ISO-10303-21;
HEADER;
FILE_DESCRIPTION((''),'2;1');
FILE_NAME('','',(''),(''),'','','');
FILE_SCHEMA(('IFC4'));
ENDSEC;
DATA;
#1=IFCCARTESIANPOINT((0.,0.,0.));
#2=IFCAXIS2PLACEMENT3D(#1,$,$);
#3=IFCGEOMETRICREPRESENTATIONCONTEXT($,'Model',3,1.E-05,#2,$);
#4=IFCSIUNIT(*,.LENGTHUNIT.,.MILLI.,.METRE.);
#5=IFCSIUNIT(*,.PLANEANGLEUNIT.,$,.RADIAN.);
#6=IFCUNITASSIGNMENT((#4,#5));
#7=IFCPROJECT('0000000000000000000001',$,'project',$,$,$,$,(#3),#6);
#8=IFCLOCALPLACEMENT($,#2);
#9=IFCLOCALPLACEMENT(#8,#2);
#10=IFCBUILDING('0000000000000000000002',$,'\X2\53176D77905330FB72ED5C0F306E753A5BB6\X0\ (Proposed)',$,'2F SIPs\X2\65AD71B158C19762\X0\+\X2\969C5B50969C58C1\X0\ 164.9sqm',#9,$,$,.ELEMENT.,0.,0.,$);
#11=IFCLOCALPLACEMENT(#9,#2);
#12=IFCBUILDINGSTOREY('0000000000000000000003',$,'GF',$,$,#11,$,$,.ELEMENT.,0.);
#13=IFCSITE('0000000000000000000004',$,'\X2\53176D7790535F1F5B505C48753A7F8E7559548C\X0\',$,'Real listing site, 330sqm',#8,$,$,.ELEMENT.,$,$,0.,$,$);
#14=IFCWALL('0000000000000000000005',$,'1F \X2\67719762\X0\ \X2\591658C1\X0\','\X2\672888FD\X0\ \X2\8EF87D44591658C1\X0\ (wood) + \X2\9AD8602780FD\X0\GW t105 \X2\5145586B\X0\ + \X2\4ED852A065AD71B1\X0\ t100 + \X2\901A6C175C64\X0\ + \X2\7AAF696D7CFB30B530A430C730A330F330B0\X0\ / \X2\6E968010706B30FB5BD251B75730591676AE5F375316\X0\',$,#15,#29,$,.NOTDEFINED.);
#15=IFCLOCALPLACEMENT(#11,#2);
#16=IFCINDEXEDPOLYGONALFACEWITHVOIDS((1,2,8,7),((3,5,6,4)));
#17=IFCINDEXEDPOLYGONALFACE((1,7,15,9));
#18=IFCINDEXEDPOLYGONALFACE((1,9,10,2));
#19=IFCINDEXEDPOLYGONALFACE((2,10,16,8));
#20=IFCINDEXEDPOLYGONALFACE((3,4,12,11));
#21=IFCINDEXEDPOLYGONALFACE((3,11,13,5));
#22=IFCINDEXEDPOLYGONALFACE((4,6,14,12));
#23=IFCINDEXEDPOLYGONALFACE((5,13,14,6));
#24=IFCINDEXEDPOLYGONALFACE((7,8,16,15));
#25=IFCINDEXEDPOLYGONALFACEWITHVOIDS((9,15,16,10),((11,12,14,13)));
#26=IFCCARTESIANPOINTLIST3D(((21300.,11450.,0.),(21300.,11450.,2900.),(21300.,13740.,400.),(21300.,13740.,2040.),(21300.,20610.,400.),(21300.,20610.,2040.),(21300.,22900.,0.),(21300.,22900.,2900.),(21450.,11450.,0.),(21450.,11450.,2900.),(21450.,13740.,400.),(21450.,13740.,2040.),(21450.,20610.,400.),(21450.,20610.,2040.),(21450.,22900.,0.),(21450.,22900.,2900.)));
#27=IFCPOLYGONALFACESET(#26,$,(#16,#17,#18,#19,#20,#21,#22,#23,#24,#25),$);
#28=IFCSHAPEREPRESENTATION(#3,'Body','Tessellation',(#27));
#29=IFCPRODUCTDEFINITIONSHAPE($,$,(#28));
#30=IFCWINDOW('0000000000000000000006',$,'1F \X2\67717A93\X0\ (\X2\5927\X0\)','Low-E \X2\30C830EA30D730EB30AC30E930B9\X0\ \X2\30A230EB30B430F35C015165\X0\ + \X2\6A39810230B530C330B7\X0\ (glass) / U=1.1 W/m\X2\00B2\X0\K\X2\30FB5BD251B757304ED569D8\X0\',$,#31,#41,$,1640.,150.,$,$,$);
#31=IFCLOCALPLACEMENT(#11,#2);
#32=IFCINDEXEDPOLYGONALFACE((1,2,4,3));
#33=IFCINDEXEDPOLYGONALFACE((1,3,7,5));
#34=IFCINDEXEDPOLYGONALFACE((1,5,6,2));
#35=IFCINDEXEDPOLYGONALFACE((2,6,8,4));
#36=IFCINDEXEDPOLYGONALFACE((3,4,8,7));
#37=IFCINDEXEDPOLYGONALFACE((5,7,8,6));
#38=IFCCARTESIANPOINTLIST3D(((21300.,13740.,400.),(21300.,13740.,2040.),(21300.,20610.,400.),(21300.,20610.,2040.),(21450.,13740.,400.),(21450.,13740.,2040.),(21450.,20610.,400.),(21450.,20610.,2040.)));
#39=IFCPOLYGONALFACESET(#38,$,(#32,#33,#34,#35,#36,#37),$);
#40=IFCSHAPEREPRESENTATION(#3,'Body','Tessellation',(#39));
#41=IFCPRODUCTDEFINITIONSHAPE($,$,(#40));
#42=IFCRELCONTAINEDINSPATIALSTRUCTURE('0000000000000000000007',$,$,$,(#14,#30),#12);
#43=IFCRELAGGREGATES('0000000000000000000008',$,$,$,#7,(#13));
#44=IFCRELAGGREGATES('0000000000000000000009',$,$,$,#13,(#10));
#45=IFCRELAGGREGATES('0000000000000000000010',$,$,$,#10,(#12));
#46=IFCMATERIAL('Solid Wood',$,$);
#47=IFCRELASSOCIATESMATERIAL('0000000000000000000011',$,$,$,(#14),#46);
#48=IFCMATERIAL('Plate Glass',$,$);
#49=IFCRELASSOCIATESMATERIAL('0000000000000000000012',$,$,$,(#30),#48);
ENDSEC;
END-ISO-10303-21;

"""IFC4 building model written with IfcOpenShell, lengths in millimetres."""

from ifc_helpers import new_model, si_unit, frame, frame_2d, origin, place, context, project, spatial, rectangle, extrude, material, element, fill, save


model = new_model("IFC4")

# Units and contexts
model_context = context("Model", 3, precision=1e-05, world=origin())
ifc_project = project(units=[si_unit("LENGTHUNIT", "METRE", prefix="MILLI"), si_unit("PLANEANGLEUNIT", "RADIAN")], contexts=[model_context])

# Site, building, storey
site_placement = place(None, origin())
site = spatial("IfcSite", under=ifc_project, at=site_placement, Name="北海道弟子屈町美留和", ObjectType="Real listing site, 330sqm", CompositionType="ELEMENT", RefElevation=0.0)
building_placement = place(site_placement, origin())
building = spatial("IfcBuilding", under=site, at=building_placement, Name="北海道・狭小の町家 (Proposed)", ObjectType="2F SIPs断熱壁面+障子障壁 164.9sqm", CompositionType="ELEMENT", ElevationOfRefHeight=0.0, ElevationOfTerrain=0.0)
storey_placement = place(building_placement, origin())
storey = spatial("IfcBuildingStorey", under=building, at=storey_placement, Name="GF", CompositionType="ELEMENT", Elevation=0.0)

# Shared definitions
ifc_material_1 = material(Name="Solid Wood")

# Wall, opening, window
wall_1_placement = place(storey_placement, frame((10650.0, 5725.0, 0.0)))
wall_1 = element("IfcWall", 1, at=wall_1_placement, inside=storey, material=ifc_material_1, Name="1F 東面 外壁", Description="木製 軸組外壁 (wood) + 高性能GW t105 充填 + 付加断熱 t100 + 通気層 + 窯業系サイディング / 準耐火・寒冷地外皮強化", PredefinedType="NOTDEFINED", context=model_context, shape_type="SweptSolid", body=[
    extrude(rectangle(XDim=150.0, YDim=11450.0, at=frame_2d((75.0, 5725.0))), frame((10650.0, 5725.0, 0.0)), (0.0, 0.0, 1.0), 2900.0),
])
opening_1_placement = place(storey_placement, frame((10650.0, 6870.0, 200.0)))
opening_1 = element("IfcOpeningElement", 2, at=opening_1_placement, cuts=wall_1, PredefinedType="NOTDEFINED", context=model_context, shape_type="SweptSolid", body=[
    extrude(rectangle(XDim=150.0, YDim=6870.0, at=frame_2d((75.0, 3435.0))), frame((10650.0, 6870.0, 200.0)), (0.0, 0.0, 1.0), 1640.0),
])
ifc_material_2 = material(Name="Plate Glass")
window_1_placement = place(storey_placement, frame((10650.0, 6870.0, 200.0)))
window_1 = element("IfcWindow", 3, at=window_1_placement, inside=storey, material=ifc_material_2, Name="1F 東窓 (大)", Description="Low-E トリプルガラス アルゴン封入 + 樹脂サッシ (glass) / U=1.1 W/m²K・寒冷地仕様", OverallHeight=1640.0, OverallWidth=150.0, context=model_context, shape_type="SweptSolid", body=[
    extrude(rectangle(XDim=150.0, YDim=6870.0, at=frame_2d((75.0, 3435.0))), frame((10650.0, 6870.0, 200.0)), (0.0, 0.0, 1.0), 1640.0),
])
fill(opening_1, window_1)

save(model, "model.ifc")
